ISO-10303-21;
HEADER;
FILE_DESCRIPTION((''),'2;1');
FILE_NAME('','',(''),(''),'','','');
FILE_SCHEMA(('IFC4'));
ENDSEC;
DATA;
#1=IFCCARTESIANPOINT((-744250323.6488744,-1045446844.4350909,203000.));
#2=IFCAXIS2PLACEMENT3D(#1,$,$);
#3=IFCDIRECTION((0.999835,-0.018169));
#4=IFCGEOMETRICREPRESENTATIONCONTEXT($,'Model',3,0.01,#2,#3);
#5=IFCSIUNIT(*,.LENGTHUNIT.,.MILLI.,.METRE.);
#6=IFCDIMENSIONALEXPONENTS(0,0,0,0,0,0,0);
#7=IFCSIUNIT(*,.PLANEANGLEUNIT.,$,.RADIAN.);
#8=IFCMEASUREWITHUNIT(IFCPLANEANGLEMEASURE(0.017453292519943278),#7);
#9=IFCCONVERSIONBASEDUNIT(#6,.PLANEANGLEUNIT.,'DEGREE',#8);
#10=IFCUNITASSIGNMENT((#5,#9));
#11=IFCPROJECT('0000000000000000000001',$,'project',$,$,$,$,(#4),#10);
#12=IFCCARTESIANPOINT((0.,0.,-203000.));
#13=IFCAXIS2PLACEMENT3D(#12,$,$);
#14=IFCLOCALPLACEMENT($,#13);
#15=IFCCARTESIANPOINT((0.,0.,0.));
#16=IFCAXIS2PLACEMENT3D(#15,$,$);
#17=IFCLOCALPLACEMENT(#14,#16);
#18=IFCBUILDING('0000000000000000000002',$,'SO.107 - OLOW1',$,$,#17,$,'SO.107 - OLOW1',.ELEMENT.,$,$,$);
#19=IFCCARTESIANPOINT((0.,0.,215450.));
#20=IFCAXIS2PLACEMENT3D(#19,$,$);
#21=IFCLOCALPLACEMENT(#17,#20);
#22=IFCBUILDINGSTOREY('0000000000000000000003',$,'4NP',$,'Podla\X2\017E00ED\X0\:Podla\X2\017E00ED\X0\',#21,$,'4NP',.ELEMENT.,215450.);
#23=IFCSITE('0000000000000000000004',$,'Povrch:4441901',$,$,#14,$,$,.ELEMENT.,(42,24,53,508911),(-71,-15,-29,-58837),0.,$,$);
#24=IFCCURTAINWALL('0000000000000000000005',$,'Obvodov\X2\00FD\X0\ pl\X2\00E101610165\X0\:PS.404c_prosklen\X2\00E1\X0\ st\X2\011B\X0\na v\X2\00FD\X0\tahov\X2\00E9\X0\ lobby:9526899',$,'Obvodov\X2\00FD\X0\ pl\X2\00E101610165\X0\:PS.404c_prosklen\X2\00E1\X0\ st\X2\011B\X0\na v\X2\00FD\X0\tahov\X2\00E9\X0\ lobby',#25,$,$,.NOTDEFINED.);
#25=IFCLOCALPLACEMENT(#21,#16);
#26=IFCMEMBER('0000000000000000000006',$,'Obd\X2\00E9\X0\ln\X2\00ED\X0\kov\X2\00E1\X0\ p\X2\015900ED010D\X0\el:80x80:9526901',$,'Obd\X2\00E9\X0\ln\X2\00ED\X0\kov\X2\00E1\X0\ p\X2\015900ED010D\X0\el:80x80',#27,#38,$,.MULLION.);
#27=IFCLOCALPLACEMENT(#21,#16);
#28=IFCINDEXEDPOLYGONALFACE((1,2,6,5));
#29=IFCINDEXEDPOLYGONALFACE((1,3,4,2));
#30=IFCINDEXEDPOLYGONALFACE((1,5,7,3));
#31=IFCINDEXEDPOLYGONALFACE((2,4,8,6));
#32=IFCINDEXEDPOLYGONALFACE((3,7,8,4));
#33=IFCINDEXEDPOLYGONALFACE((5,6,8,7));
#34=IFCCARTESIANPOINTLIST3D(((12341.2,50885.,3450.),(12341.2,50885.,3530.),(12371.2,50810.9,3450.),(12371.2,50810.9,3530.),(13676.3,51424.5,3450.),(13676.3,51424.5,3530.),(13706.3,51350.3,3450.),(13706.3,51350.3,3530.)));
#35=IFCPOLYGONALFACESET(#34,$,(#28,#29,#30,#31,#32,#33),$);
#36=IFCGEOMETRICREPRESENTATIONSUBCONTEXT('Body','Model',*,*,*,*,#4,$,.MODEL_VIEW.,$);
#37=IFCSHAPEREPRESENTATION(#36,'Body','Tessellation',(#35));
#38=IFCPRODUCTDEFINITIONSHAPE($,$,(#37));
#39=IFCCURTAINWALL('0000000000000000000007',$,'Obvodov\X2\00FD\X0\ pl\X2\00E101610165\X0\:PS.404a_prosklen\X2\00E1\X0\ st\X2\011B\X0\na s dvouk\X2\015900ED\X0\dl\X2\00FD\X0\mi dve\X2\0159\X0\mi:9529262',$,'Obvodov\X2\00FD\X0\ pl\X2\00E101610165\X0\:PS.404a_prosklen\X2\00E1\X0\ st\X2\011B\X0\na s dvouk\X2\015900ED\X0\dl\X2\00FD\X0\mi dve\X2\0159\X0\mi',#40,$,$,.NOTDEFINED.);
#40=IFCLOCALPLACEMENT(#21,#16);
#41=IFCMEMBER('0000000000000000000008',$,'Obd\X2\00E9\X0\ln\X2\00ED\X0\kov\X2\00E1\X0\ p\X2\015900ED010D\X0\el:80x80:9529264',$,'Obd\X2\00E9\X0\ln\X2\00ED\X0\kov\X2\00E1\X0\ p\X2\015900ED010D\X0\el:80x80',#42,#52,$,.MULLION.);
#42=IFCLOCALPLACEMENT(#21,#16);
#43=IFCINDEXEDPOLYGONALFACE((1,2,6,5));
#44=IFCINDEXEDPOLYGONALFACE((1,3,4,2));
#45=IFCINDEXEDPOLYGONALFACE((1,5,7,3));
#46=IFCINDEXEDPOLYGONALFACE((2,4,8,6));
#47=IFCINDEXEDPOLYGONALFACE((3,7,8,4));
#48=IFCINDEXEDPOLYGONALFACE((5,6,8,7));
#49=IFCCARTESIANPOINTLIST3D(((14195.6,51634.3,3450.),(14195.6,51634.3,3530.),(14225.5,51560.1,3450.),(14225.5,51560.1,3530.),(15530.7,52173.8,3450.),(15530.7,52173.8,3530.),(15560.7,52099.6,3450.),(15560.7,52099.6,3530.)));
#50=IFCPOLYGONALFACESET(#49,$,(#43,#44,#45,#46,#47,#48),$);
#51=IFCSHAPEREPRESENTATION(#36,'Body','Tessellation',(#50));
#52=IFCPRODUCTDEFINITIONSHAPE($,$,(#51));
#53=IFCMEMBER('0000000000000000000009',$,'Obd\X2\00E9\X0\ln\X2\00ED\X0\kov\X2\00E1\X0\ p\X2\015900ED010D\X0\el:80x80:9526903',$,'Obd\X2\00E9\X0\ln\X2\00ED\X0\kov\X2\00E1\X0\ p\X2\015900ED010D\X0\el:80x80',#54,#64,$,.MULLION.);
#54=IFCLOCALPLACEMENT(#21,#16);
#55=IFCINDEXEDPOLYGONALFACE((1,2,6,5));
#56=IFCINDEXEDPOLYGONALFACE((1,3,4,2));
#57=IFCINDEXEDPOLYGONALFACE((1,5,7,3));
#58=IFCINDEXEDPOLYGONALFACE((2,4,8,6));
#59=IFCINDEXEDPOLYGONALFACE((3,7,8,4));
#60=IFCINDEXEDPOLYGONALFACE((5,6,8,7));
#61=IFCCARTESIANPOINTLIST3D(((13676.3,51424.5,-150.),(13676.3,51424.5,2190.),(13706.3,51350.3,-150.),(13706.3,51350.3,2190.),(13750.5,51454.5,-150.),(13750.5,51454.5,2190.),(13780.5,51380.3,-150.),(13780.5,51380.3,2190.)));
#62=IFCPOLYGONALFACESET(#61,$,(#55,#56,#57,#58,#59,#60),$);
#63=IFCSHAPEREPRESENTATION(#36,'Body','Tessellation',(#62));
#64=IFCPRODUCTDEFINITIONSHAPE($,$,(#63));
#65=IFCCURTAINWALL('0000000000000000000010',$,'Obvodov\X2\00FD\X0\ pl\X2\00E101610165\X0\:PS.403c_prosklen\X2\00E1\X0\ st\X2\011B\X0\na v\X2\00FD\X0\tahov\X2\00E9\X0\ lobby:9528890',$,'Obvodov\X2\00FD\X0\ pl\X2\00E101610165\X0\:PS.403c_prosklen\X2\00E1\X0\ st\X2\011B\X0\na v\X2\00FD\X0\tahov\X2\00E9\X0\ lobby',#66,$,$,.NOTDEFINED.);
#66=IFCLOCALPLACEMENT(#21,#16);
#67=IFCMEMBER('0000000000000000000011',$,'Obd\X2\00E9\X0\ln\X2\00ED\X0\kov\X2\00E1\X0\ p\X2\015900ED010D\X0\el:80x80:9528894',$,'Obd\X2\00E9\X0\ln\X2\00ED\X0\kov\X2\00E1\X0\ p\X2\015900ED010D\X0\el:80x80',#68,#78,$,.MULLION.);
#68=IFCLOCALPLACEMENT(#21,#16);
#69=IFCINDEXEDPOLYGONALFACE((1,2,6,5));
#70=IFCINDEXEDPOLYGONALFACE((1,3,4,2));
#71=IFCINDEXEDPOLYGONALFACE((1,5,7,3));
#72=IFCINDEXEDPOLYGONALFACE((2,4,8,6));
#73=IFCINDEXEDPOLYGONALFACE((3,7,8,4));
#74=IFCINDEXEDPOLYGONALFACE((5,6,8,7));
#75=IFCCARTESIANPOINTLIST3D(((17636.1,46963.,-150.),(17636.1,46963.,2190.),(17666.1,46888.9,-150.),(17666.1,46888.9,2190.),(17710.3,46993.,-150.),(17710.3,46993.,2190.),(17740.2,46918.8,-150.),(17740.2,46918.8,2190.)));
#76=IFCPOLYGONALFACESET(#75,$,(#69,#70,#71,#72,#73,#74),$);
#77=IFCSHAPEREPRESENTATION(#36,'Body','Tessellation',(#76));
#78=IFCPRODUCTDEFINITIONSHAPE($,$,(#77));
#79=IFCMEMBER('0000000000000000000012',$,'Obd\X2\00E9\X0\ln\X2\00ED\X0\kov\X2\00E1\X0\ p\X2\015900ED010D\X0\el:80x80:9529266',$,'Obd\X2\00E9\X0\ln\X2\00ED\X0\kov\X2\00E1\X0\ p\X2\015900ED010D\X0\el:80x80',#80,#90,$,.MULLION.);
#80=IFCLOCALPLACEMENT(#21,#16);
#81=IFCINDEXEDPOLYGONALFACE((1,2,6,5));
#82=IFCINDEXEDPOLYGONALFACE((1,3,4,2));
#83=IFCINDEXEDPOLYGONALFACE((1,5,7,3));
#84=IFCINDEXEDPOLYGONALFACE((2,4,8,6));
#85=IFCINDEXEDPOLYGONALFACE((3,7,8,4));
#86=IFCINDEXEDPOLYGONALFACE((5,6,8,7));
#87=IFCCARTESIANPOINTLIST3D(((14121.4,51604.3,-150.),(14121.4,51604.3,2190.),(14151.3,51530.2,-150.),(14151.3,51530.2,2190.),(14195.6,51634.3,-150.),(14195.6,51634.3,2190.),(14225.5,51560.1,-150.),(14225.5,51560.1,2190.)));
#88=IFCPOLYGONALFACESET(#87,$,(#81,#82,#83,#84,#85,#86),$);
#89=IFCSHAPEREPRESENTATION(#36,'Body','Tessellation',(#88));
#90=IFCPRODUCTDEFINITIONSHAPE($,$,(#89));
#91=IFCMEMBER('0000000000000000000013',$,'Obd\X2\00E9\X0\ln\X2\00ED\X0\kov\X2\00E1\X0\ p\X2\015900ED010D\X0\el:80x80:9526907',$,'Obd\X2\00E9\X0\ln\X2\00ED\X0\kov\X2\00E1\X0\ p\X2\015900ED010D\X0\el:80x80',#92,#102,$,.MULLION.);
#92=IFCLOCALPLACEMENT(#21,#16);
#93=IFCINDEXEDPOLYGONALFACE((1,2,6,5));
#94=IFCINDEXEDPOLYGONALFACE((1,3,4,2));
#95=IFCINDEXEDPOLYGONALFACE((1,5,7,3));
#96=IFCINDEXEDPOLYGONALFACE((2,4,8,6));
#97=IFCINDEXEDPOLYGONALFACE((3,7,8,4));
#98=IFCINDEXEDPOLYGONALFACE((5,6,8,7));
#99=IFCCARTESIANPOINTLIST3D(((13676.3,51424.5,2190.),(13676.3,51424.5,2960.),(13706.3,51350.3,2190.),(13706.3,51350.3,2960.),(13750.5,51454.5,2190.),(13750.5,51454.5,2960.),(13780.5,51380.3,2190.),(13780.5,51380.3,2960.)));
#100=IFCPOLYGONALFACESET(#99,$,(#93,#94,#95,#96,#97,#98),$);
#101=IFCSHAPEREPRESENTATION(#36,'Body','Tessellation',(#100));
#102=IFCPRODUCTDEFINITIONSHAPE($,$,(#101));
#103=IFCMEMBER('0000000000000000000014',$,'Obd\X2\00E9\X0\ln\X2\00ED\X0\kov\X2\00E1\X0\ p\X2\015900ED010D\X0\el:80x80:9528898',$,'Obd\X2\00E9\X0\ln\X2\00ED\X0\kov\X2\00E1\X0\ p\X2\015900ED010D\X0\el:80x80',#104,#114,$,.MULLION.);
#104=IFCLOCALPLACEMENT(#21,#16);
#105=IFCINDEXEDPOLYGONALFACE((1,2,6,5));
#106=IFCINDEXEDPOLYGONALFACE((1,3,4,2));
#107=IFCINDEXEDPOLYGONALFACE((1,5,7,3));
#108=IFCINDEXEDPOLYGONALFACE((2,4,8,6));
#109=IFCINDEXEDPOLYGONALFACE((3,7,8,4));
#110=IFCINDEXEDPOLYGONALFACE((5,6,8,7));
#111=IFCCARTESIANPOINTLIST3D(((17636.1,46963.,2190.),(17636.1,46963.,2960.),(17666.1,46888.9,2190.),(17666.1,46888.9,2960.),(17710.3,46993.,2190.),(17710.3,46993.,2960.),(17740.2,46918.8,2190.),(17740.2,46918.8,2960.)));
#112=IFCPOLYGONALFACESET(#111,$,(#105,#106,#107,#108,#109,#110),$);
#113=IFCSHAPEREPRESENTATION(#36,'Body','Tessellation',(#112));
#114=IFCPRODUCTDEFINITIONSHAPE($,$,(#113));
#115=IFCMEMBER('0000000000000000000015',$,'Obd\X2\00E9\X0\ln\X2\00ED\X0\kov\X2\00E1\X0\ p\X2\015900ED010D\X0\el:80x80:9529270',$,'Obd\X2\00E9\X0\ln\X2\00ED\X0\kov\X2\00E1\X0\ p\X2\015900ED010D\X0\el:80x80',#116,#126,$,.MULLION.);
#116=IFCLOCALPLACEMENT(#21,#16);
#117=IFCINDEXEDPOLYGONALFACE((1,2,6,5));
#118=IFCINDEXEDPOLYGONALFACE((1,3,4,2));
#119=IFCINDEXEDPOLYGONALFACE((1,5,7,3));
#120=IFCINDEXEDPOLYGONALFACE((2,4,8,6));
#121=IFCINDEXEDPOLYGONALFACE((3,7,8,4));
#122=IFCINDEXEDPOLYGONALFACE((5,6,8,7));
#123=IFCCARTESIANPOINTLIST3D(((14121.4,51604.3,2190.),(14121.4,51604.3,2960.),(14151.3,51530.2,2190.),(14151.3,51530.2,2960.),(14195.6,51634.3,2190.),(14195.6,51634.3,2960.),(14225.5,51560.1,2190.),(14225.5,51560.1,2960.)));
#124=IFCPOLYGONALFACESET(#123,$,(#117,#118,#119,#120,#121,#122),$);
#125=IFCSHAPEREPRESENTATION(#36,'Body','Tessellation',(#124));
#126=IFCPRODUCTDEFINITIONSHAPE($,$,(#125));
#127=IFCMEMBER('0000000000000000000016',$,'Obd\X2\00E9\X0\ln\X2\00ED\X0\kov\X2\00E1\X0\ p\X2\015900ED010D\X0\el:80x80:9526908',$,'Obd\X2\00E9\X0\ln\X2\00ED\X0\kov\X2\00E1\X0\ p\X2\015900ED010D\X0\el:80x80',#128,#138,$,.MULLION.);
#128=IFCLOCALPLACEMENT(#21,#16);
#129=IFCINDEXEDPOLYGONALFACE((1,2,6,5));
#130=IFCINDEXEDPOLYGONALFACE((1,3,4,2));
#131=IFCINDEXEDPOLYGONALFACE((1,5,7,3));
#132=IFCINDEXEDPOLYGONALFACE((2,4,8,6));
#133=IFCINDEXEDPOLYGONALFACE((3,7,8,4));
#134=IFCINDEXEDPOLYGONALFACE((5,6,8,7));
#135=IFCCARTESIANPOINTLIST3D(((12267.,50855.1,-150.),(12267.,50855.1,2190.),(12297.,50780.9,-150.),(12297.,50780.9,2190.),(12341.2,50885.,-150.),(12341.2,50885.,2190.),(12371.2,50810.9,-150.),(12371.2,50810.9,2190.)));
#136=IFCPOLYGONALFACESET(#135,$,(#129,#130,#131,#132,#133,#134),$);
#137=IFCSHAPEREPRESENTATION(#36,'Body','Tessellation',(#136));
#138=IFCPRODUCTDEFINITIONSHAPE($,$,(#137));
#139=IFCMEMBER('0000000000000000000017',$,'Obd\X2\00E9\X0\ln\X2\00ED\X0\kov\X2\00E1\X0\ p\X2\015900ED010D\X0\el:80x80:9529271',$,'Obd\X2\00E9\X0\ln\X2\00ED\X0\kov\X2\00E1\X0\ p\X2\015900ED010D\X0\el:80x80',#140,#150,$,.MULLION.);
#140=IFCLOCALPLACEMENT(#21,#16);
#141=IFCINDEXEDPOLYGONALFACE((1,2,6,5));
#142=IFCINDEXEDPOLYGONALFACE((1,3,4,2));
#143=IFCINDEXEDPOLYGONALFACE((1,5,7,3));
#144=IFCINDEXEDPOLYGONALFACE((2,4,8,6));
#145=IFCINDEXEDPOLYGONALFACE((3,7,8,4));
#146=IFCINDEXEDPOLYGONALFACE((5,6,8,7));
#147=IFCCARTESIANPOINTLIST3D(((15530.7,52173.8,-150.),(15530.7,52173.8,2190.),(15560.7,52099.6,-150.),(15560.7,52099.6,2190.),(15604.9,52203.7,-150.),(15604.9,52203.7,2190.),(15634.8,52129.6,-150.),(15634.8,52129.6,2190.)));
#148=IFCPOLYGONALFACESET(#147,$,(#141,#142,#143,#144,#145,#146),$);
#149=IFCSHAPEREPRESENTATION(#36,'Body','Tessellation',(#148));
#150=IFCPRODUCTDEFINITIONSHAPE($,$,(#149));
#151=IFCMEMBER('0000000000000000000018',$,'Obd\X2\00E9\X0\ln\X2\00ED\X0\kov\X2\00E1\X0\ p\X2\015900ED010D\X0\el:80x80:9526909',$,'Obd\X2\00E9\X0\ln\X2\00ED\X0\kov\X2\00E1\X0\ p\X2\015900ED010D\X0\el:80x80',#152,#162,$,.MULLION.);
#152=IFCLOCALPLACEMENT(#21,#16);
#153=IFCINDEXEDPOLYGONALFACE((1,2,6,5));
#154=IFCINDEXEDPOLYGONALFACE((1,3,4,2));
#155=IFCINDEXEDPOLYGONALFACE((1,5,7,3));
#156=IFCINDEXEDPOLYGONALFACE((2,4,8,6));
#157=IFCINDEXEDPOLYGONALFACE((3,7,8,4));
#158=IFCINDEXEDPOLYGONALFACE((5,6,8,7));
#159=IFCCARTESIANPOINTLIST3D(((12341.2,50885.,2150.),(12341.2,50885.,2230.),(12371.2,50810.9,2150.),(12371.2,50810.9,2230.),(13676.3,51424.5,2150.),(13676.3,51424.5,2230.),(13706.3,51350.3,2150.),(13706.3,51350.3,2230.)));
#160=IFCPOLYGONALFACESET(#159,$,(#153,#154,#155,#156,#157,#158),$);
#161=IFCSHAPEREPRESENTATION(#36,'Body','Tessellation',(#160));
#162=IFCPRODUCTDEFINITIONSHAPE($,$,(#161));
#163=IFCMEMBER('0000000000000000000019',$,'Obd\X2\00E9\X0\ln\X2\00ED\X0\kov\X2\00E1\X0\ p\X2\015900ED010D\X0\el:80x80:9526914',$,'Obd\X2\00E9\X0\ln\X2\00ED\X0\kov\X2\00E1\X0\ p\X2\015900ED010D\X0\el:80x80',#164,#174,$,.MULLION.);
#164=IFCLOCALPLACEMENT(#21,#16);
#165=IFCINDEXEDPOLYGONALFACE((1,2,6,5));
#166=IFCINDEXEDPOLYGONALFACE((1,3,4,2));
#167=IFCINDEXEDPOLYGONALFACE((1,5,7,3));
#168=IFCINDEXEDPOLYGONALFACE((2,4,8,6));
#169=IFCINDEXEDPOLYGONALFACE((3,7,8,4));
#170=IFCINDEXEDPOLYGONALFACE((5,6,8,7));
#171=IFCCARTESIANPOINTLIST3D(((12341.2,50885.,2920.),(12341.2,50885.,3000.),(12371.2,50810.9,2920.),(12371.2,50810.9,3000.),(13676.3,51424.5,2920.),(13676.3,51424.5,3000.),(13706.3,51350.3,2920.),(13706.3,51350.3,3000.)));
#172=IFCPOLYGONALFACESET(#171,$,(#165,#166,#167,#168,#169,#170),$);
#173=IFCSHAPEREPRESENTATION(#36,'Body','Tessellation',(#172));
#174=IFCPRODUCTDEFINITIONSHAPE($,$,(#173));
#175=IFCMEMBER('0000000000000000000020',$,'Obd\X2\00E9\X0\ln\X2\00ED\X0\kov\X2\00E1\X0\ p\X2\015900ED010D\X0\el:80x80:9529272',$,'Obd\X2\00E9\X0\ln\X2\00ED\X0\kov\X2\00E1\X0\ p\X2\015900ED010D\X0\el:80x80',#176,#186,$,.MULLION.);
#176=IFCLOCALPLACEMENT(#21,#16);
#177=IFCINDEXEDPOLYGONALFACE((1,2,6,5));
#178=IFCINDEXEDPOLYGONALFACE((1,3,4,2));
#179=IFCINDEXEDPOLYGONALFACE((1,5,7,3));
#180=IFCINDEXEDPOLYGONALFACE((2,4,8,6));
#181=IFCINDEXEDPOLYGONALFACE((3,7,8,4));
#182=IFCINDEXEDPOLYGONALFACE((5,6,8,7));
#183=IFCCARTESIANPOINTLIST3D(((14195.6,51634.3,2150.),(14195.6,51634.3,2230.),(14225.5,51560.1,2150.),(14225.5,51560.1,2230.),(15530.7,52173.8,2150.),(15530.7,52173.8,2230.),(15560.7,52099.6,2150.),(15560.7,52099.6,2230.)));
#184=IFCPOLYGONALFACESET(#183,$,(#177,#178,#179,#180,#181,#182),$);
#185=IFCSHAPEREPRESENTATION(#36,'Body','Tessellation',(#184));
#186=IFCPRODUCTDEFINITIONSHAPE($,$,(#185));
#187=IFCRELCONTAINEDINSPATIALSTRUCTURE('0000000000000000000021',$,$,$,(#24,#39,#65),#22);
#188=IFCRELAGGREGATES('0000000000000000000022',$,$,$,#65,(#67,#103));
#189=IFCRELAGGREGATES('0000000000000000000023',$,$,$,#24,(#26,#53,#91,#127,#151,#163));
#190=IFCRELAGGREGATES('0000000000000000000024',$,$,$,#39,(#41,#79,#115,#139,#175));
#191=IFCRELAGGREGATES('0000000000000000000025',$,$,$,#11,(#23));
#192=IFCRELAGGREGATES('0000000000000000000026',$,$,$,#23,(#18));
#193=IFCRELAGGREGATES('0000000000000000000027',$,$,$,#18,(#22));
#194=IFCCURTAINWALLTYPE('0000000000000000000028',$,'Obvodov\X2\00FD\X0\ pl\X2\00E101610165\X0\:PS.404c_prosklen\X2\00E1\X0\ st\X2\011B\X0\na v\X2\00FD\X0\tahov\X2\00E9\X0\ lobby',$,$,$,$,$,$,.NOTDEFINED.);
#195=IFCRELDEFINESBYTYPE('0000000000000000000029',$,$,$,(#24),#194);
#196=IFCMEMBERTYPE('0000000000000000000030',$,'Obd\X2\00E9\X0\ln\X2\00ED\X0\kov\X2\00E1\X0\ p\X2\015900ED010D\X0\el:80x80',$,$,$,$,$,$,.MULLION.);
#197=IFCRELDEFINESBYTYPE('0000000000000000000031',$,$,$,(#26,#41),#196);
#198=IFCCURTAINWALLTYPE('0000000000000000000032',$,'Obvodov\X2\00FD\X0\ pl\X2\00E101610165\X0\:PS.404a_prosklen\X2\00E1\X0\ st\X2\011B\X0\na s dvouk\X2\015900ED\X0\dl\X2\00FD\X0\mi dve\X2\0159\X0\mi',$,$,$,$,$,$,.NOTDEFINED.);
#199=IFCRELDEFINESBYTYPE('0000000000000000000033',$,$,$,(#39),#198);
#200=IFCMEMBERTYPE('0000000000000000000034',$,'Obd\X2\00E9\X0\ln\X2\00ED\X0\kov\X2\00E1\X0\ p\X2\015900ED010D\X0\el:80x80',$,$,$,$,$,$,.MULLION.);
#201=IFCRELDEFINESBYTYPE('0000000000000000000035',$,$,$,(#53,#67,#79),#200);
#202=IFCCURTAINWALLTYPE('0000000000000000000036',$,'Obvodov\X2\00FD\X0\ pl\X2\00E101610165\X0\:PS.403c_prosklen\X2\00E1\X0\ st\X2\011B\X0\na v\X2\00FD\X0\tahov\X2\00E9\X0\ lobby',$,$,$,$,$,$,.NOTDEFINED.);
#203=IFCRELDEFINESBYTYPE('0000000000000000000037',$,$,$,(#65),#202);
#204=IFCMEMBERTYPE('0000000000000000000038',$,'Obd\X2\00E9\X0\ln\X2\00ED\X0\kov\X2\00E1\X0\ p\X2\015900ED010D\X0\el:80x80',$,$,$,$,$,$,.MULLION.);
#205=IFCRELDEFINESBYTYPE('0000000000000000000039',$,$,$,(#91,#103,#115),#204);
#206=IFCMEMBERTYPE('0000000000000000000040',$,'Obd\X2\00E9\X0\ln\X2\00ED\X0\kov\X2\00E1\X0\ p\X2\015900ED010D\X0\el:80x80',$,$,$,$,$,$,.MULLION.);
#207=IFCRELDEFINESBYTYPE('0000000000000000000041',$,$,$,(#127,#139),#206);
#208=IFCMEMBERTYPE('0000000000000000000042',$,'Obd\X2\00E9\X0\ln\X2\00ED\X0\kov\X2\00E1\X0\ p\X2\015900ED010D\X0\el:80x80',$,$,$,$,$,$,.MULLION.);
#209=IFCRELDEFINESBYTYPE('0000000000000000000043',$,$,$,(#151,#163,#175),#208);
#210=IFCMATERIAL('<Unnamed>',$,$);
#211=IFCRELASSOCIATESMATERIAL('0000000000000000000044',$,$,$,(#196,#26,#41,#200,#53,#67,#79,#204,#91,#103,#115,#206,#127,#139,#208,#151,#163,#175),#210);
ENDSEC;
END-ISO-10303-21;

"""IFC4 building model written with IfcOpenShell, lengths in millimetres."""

from ifc_helpers import new_model, entity, si_unit, converted_unit, direction, frame, origin, place, context, subcontext, project, spatial, indexed_curve, outline, extrude, source, transform, mapped, material, type_object, type_shapes, element, aggregate, save


model = new_model("IFC4")

# Units and contexts
model_context = context("Model", 3, precision=0.01, world=frame((-744250323.6488744, -1045446844.4350909, 203000.0)), true_north=direction((0.999835, -0.018169)))
body_context = subcontext(model_context, "Body", "Model", "MODEL_VIEW")
ifc_project = project(units=[si_unit("LENGTHUNIT", "METRE", prefix="MILLI"), converted_unit("PLANEANGLEUNIT", "DEGREE", entity("IfcPlaneAngleMeasure", 0.017453292519943278), si_unit("PLANEANGLEUNIT", "RADIAN"), dimensions=[0, 0, 0, 0, 0, 0, 0])], contexts=[model_context])

# Site, building, storey
site_placement = place(None, frame((0.0, 0.0, -203000.0)))
site = spatial("IfcSite", under=ifc_project, at=site_placement, Name="Povrch:4441901", CompositionType="ELEMENT", RefLatitude=(42, 24, 53, 508911), RefLongitude=(-71, -15, -29, -58837), RefElevation=0.0)
building_placement = place(site_placement, origin())
building = spatial("IfcBuilding", under=site, at=building_placement, Name="SO.107 - OLOW1", LongName="SO.107 - OLOW1", CompositionType="ELEMENT")
storey_placement = place(building_placement, frame((0.0, 0.0, 215450.0)))
storey = spatial("IfcBuildingStorey", under=building, at=storey_placement, Name="4NP", ObjectType="Podlaží:Podlaží", LongName="4NP", CompositionType="ELEMENT", Elevation=215450.0)

# Curtain walls, members
curtain_wall_type_1 = type_object("IfcCurtainWallType", Name="Obvodový plášť:PS.404c_prosklená stěna výtahové lobby", PredefinedType="NOTDEFINED")
curtain_wall_1_placement = place(storey_placement, frame((0.0, 0.0, -215450.0)))
curtain_wall_1 = element("IfcCurtainWall", 1, at=curtain_wall_1_placement, inside=storey, type_object=curtain_wall_type_1, Name="Obvodový plášť:PS.404c_prosklená stěna výtahové lobby:9526899", ObjectType="Obvodový plášť:PS.404c_prosklená stěna výtahové lobby", PredefinedType="NOTDEFINED")
ifc_material_1 = material(Name="<Unnamed>")
member_type_1 = type_object("IfcMemberType", Name="Obdélníková příčel:80x80", PredefinedType="MULLION", material=ifc_material_1)
shared_shape_1 = source(origin(), body_context, "Body", "SweptSolid", [
    extrude(outline(indexed_curve([(-40.0, -40.0), (40.0, -40.0), (40.0, 40.0), (-40.0, 40.0), (-40.0, -40.0)], self_intersect=False)), frame((-40.0, 0.0, -1440.0), z_axis=(0.0, 0.0, 1.0), x_axis=(-1.0, 0.0, 0.0)), (0.0, 0.0, 1.0), 1440.0),
])
type_shapes(member_type_1, [shared_shape_1])
member_1_placement = place(curtain_wall_1_placement, frame((13691.3, 51387.4, 218980.0), z_axis=(0.927176, 0.374626, 0.0), x_axis=(0.0, 0.0, 1.0)))
member_1 = element("IfcMember", 2, at=member_1_placement, type_object=member_type_1, material=ifc_material_1, Name="Obdélníková příčel:80x80:9526901", ObjectType="Obdélníková příčel:80x80", PredefinedType="MULLION", context=body_context, shape_type="MappedRepresentation", body=[
    mapped(shared_shape_1, transform((0.0, 0.0, 0.0), scale=1.0)),
])
curtain_wall_type_2 = type_object("IfcCurtainWallType", Name="Obvodový plášť:PS.404a_prosklená stěna s dvoukřídlými dveřmi", PredefinedType="NOTDEFINED")
curtain_wall_2_placement = place(storey_placement, frame((0.0, 0.0, -215450.0)))
curtain_wall_2 = element("IfcCurtainWall", 3, at=curtain_wall_2_placement, inside=storey, type_object=curtain_wall_type_2, Name="Obvodový plášť:PS.404a_prosklená stěna s dvoukřídlými dveřmi:9529262", ObjectType="Obvodový plášť:PS.404a_prosklená stěna s dvoukřídlými dveřmi", PredefinedType="NOTDEFINED")
member_2_placement = place(curtain_wall_2_placement, frame((14210.5, 51597.2, 218980.0), z_axis=(-0.927176, -0.374626, 0.0), x_axis=(0.0, 0.0, 1.0)))
member_2 = element("IfcMember", 4, at=member_2_placement, type_object=member_type_1, material=ifc_material_1, Name="Obdélníková příčel:80x80:9529264", ObjectType="Obdélníková příčel:80x80", PredefinedType="MULLION", context=body_context, shape_type="MappedRepresentation", body=[
    mapped(shared_shape_1, transform((0.0, 0.0, 0.0), scale=1.0)),
])

# Member
member_type_2 = type_object("IfcMemberType", Name="Obdélníková příčel:80x80", PredefinedType="MULLION", material=ifc_material_1)
shared_shape_2 = source(origin(), body_context, "Body", "SweptSolid", [
    extrude(outline(indexed_curve([(-40.0, -40.0), (40.0, -40.0), (40.0, 40.0), (-40.0, 40.0), (-40.0, -40.0)], self_intersect=False)), frame((-40.0, 0.0, -2340.0), z_axis=(0.0, 0.0, 1.0), x_axis=(-1.0, 0.0, 0.0)), (0.0, 0.0, 1.0), 2340.0),
])
type_shapes(member_type_2, [shared_shape_2])
member_3_placement = place(curtain_wall_1_placement, frame((13765.5, 51417.4, 215300.0), z_axis=(0.0, 0.0, -1.0), x_axis=(0.927176, 0.374626, 0.0)))
member_3 = element("IfcMember", 5, at=member_3_placement, type_object=member_type_2, material=ifc_material_1, Name="Obdélníková příčel:80x80:9526903", ObjectType="Obdélníková příčel:80x80", PredefinedType="MULLION", context=body_context, shape_type="MappedRepresentation", body=[
    mapped(shared_shape_2, transform((0.0, 0.0, 0.0), scale=1.0)),
])

# Curtain wall, member
curtain_wall_type_3 = type_object("IfcCurtainWallType", Name="Obvodový plášť:PS.403c_prosklená stěna výtahové lobby", PredefinedType="NOTDEFINED")
curtain_wall_3_placement = place(storey_placement, frame((0.0, 0.0, -215450.0)))
curtain_wall_3 = element("IfcCurtainWall", 6, at=curtain_wall_3_placement, inside=storey, type_object=curtain_wall_type_3, Name="Obvodový plášť:PS.403c_prosklená stěna výtahové lobby:9528890", ObjectType="Obvodový plášť:PS.403c_prosklená stěna výtahové lobby", PredefinedType="NOTDEFINED")
member_4_placement = place(curtain_wall_3_placement, frame((17725.2, 46955.9, 215300.0), z_axis=(0.0, 0.0, -1.0), x_axis=(0.927176, 0.374626, 0.0)))
member_4 = element("IfcMember", 7, at=member_4_placement, type_object=member_type_2, material=ifc_material_1, Name="Obdélníková příčel:80x80:9528894", ObjectType="Obdélníková příčel:80x80", PredefinedType="MULLION", context=body_context, shape_type="MappedRepresentation", body=[
    mapped(shared_shape_2, transform((0.0, 0.0, 0.0), scale=1.0)),
])

# Members
member_5_placement = place(curtain_wall_2_placement, frame((14136.4, 51567.2, 215300.0), z_axis=(0.0, 0.0, -1.0), x_axis=(-0.927176, -0.374626, 0.0)))
member_5 = element("IfcMember", 8, at=member_5_placement, type_object=member_type_2, material=ifc_material_1, Name="Obdélníková příčel:80x80:9529266", ObjectType="Obdélníková příčel:80x80", PredefinedType="MULLION", context=body_context, shape_type="MappedRepresentation", body=[
    mapped(shared_shape_2, transform((0.0, 0.0, 0.0), scale=1.0)),
])
member_type_3 = type_object("IfcMemberType", Name="Obdélníková příčel:80x80", PredefinedType="MULLION", material=ifc_material_1)
shared_shape_3 = source(origin(), body_context, "Body", "SweptSolid", [
    extrude(outline(indexed_curve([(-40.0, -40.0), (40.0, -40.0), (40.0, 40.0), (-40.0, 40.0), (-40.0, -40.0)], self_intersect=False)), frame((-40.0, 0.0, -770.0), z_axis=(0.0, 0.0, 1.0), x_axis=(-1.0, 0.0, 0.0)), (0.0, 0.0, 1.0), 770.0),
])
type_shapes(member_type_3, [shared_shape_3])
member_6_placement = place(curtain_wall_1_placement, frame((13765.5, 51417.4, 217640.0), z_axis=(0.0, 0.0, -1.0), x_axis=(0.927176, 0.374626, 0.0)))
member_6 = element("IfcMember", 9, at=member_6_placement, type_object=member_type_3, material=ifc_material_1, Name="Obdélníková příčel:80x80:9526907", ObjectType="Obdélníková příčel:80x80", PredefinedType="MULLION", context=body_context, shape_type="MappedRepresentation", body=[
    mapped(shared_shape_3, transform((0.0, 0.0, 0.0), scale=1.0)),
])
member_7_placement = place(curtain_wall_3_placement, frame((17725.2, 46955.9, 217640.0), z_axis=(0.0, 0.0, -1.0), x_axis=(0.927176, 0.374626, 0.0)))
member_7 = element("IfcMember", 10, at=member_7_placement, type_object=member_type_3, material=ifc_material_1, Name="Obdélníková příčel:80x80:9528898", ObjectType="Obdélníková příčel:80x80", PredefinedType="MULLION", context=body_context, shape_type="MappedRepresentation", body=[
    mapped(shared_shape_3, transform((0.0, 0.0, 0.0), scale=1.0)),
])
member_8_placement = place(curtain_wall_2_placement, frame((14136.4, 51567.2, 217640.0), z_axis=(0.0, 0.0, -1.0), x_axis=(-0.927176, -0.374626, 0.0)))
member_8 = element("IfcMember", 11, at=member_8_placement, type_object=member_type_3, material=ifc_material_1, Name="Obdélníková příčel:80x80:9529270", ObjectType="Obdélníková příčel:80x80", PredefinedType="MULLION", context=body_context, shape_type="MappedRepresentation", body=[
    mapped(shared_shape_3, transform((0.0, 0.0, 0.0), scale=1.0)),
])
member_type_4 = type_object("IfcMemberType", Name="Obdélníková příčel:80x80", PredefinedType="MULLION", material=ifc_material_1)
shared_shape_4 = source(origin(), body_context, "Body", "SweptSolid", [
    extrude(outline(indexed_curve([(-40.0, -40.0), (40.0, -40.0), (40.0, 40.0), (-40.0, 40.0), (-40.0, -40.0)], self_intersect=False)), frame((-40.0, 0.0, -2340.0), z_axis=(0.0, 0.0, 1.0), x_axis=(-1.0, 0.0, 0.0)), (0.0, 0.0, 1.0), 2340.0),
])
type_shapes(member_type_4, [shared_shape_4])
member_9_placement = place(curtain_wall_1_placement, frame((12282.0, 50818.0, 217640.0), z_axis=(0.0, 0.0, 1.0), x_axis=(-0.927176, -0.374626, 0.0)))
member_9 = element("IfcMember", 12, at=member_9_placement, type_object=member_type_4, material=ifc_material_1, Name="Obdélníková příčel:80x80:9526908", ObjectType="Obdélníková příčel:80x80", PredefinedType="MULLION", context=body_context, shape_type="MappedRepresentation", body=[
    mapped(shared_shape_4, transform((0.0, 0.0, 0.0), scale=1.0)),
])
member_10_placement = place(curtain_wall_2_placement, frame((15619.8, 52166.6, 217640.0), z_axis=(0.0, 0.0, 1.0), x_axis=(0.927176, 0.374626, 0.0)))
member_10 = element("IfcMember", 13, at=member_10_placement, type_object=member_type_4, material=ifc_material_1, Name="Obdélníková příčel:80x80:9529271", ObjectType="Obdélníková příčel:80x80", PredefinedType="MULLION", context=body_context, shape_type="MappedRepresentation", body=[
    mapped(shared_shape_4, transform((0.0, 0.0, 0.0), scale=1.0)),
])
member_type_5 = type_object("IfcMemberType", Name="Obdélníková příčel:80x80", PredefinedType="MULLION", material=ifc_material_1)
shared_shape_5 = source(origin(), body_context, "Body", "SweptSolid", [
    extrude(outline(indexed_curve([(-40.0, -40.0), (40.0, -40.0), (40.0, 40.0), (-40.0, 40.0), (-40.0, -40.0)], self_intersect=False)), frame((0.0, 0.0, -1440.0), z_axis=(0.0, 0.0, 1.0), x_axis=(-1.0, 0.0, 0.0)), (0.0, 0.0, 1.0), 1440.0),
])
type_shapes(member_type_5, [shared_shape_5])
member_11_placement = place(curtain_wall_1_placement, frame((13691.3, 51387.4, 217640.0), z_axis=(0.927176, 0.374626, 0.0), x_axis=(0.0, 0.0, 1.0)))
member_11 = element("IfcMember", 14, at=member_11_placement, type_object=member_type_5, material=ifc_material_1, Name="Obdélníková příčel:80x80:9526909", ObjectType="Obdélníková příčel:80x80", PredefinedType="MULLION", context=body_context, shape_type="MappedRepresentation", body=[
    mapped(shared_shape_5, transform((0.0, 0.0, 0.0), scale=1.0)),
])
member_12_placement = place(curtain_wall_1_placement, frame((13691.3, 51387.4, 218410.0), z_axis=(0.927176, 0.374626, 0.0), x_axis=(0.0, 0.0, 1.0)))
member_12 = element("IfcMember", 15, at=member_12_placement, type_object=member_type_5, material=ifc_material_1, Name="Obdélníková příčel:80x80:9526914", ObjectType="Obdélníková příčel:80x80", PredefinedType="MULLION", context=body_context, shape_type="MappedRepresentation", body=[
    mapped(shared_shape_5, transform((0.0, 0.0, 0.0), scale=1.0)),
])
member_13_placement = place(curtain_wall_2_placement, frame((14210.5, 51597.2, 217640.0), z_axis=(-0.927176, -0.374626, 0.0), x_axis=(0.0, 0.0, 1.0)))
member_13 = element("IfcMember", 16, at=member_13_placement, type_object=member_type_5, material=ifc_material_1, Name="Obdélníková příčel:80x80:9529272", ObjectType="Obdélníková příčel:80x80", PredefinedType="MULLION", context=body_context, shape_type="MappedRepresentation", body=[
    mapped(shared_shape_5, transform((0.0, 0.0, 0.0), scale=1.0)),
])
aggregate(curtain_wall_3, [member_4, member_7])

aggregate(curtain_wall_1, [member_1, member_3, member_6, member_9, member_11, member_12])

aggregate(curtain_wall_2, [member_2, member_5, member_8, member_10, member_13])

save(model, "model.ifc")
